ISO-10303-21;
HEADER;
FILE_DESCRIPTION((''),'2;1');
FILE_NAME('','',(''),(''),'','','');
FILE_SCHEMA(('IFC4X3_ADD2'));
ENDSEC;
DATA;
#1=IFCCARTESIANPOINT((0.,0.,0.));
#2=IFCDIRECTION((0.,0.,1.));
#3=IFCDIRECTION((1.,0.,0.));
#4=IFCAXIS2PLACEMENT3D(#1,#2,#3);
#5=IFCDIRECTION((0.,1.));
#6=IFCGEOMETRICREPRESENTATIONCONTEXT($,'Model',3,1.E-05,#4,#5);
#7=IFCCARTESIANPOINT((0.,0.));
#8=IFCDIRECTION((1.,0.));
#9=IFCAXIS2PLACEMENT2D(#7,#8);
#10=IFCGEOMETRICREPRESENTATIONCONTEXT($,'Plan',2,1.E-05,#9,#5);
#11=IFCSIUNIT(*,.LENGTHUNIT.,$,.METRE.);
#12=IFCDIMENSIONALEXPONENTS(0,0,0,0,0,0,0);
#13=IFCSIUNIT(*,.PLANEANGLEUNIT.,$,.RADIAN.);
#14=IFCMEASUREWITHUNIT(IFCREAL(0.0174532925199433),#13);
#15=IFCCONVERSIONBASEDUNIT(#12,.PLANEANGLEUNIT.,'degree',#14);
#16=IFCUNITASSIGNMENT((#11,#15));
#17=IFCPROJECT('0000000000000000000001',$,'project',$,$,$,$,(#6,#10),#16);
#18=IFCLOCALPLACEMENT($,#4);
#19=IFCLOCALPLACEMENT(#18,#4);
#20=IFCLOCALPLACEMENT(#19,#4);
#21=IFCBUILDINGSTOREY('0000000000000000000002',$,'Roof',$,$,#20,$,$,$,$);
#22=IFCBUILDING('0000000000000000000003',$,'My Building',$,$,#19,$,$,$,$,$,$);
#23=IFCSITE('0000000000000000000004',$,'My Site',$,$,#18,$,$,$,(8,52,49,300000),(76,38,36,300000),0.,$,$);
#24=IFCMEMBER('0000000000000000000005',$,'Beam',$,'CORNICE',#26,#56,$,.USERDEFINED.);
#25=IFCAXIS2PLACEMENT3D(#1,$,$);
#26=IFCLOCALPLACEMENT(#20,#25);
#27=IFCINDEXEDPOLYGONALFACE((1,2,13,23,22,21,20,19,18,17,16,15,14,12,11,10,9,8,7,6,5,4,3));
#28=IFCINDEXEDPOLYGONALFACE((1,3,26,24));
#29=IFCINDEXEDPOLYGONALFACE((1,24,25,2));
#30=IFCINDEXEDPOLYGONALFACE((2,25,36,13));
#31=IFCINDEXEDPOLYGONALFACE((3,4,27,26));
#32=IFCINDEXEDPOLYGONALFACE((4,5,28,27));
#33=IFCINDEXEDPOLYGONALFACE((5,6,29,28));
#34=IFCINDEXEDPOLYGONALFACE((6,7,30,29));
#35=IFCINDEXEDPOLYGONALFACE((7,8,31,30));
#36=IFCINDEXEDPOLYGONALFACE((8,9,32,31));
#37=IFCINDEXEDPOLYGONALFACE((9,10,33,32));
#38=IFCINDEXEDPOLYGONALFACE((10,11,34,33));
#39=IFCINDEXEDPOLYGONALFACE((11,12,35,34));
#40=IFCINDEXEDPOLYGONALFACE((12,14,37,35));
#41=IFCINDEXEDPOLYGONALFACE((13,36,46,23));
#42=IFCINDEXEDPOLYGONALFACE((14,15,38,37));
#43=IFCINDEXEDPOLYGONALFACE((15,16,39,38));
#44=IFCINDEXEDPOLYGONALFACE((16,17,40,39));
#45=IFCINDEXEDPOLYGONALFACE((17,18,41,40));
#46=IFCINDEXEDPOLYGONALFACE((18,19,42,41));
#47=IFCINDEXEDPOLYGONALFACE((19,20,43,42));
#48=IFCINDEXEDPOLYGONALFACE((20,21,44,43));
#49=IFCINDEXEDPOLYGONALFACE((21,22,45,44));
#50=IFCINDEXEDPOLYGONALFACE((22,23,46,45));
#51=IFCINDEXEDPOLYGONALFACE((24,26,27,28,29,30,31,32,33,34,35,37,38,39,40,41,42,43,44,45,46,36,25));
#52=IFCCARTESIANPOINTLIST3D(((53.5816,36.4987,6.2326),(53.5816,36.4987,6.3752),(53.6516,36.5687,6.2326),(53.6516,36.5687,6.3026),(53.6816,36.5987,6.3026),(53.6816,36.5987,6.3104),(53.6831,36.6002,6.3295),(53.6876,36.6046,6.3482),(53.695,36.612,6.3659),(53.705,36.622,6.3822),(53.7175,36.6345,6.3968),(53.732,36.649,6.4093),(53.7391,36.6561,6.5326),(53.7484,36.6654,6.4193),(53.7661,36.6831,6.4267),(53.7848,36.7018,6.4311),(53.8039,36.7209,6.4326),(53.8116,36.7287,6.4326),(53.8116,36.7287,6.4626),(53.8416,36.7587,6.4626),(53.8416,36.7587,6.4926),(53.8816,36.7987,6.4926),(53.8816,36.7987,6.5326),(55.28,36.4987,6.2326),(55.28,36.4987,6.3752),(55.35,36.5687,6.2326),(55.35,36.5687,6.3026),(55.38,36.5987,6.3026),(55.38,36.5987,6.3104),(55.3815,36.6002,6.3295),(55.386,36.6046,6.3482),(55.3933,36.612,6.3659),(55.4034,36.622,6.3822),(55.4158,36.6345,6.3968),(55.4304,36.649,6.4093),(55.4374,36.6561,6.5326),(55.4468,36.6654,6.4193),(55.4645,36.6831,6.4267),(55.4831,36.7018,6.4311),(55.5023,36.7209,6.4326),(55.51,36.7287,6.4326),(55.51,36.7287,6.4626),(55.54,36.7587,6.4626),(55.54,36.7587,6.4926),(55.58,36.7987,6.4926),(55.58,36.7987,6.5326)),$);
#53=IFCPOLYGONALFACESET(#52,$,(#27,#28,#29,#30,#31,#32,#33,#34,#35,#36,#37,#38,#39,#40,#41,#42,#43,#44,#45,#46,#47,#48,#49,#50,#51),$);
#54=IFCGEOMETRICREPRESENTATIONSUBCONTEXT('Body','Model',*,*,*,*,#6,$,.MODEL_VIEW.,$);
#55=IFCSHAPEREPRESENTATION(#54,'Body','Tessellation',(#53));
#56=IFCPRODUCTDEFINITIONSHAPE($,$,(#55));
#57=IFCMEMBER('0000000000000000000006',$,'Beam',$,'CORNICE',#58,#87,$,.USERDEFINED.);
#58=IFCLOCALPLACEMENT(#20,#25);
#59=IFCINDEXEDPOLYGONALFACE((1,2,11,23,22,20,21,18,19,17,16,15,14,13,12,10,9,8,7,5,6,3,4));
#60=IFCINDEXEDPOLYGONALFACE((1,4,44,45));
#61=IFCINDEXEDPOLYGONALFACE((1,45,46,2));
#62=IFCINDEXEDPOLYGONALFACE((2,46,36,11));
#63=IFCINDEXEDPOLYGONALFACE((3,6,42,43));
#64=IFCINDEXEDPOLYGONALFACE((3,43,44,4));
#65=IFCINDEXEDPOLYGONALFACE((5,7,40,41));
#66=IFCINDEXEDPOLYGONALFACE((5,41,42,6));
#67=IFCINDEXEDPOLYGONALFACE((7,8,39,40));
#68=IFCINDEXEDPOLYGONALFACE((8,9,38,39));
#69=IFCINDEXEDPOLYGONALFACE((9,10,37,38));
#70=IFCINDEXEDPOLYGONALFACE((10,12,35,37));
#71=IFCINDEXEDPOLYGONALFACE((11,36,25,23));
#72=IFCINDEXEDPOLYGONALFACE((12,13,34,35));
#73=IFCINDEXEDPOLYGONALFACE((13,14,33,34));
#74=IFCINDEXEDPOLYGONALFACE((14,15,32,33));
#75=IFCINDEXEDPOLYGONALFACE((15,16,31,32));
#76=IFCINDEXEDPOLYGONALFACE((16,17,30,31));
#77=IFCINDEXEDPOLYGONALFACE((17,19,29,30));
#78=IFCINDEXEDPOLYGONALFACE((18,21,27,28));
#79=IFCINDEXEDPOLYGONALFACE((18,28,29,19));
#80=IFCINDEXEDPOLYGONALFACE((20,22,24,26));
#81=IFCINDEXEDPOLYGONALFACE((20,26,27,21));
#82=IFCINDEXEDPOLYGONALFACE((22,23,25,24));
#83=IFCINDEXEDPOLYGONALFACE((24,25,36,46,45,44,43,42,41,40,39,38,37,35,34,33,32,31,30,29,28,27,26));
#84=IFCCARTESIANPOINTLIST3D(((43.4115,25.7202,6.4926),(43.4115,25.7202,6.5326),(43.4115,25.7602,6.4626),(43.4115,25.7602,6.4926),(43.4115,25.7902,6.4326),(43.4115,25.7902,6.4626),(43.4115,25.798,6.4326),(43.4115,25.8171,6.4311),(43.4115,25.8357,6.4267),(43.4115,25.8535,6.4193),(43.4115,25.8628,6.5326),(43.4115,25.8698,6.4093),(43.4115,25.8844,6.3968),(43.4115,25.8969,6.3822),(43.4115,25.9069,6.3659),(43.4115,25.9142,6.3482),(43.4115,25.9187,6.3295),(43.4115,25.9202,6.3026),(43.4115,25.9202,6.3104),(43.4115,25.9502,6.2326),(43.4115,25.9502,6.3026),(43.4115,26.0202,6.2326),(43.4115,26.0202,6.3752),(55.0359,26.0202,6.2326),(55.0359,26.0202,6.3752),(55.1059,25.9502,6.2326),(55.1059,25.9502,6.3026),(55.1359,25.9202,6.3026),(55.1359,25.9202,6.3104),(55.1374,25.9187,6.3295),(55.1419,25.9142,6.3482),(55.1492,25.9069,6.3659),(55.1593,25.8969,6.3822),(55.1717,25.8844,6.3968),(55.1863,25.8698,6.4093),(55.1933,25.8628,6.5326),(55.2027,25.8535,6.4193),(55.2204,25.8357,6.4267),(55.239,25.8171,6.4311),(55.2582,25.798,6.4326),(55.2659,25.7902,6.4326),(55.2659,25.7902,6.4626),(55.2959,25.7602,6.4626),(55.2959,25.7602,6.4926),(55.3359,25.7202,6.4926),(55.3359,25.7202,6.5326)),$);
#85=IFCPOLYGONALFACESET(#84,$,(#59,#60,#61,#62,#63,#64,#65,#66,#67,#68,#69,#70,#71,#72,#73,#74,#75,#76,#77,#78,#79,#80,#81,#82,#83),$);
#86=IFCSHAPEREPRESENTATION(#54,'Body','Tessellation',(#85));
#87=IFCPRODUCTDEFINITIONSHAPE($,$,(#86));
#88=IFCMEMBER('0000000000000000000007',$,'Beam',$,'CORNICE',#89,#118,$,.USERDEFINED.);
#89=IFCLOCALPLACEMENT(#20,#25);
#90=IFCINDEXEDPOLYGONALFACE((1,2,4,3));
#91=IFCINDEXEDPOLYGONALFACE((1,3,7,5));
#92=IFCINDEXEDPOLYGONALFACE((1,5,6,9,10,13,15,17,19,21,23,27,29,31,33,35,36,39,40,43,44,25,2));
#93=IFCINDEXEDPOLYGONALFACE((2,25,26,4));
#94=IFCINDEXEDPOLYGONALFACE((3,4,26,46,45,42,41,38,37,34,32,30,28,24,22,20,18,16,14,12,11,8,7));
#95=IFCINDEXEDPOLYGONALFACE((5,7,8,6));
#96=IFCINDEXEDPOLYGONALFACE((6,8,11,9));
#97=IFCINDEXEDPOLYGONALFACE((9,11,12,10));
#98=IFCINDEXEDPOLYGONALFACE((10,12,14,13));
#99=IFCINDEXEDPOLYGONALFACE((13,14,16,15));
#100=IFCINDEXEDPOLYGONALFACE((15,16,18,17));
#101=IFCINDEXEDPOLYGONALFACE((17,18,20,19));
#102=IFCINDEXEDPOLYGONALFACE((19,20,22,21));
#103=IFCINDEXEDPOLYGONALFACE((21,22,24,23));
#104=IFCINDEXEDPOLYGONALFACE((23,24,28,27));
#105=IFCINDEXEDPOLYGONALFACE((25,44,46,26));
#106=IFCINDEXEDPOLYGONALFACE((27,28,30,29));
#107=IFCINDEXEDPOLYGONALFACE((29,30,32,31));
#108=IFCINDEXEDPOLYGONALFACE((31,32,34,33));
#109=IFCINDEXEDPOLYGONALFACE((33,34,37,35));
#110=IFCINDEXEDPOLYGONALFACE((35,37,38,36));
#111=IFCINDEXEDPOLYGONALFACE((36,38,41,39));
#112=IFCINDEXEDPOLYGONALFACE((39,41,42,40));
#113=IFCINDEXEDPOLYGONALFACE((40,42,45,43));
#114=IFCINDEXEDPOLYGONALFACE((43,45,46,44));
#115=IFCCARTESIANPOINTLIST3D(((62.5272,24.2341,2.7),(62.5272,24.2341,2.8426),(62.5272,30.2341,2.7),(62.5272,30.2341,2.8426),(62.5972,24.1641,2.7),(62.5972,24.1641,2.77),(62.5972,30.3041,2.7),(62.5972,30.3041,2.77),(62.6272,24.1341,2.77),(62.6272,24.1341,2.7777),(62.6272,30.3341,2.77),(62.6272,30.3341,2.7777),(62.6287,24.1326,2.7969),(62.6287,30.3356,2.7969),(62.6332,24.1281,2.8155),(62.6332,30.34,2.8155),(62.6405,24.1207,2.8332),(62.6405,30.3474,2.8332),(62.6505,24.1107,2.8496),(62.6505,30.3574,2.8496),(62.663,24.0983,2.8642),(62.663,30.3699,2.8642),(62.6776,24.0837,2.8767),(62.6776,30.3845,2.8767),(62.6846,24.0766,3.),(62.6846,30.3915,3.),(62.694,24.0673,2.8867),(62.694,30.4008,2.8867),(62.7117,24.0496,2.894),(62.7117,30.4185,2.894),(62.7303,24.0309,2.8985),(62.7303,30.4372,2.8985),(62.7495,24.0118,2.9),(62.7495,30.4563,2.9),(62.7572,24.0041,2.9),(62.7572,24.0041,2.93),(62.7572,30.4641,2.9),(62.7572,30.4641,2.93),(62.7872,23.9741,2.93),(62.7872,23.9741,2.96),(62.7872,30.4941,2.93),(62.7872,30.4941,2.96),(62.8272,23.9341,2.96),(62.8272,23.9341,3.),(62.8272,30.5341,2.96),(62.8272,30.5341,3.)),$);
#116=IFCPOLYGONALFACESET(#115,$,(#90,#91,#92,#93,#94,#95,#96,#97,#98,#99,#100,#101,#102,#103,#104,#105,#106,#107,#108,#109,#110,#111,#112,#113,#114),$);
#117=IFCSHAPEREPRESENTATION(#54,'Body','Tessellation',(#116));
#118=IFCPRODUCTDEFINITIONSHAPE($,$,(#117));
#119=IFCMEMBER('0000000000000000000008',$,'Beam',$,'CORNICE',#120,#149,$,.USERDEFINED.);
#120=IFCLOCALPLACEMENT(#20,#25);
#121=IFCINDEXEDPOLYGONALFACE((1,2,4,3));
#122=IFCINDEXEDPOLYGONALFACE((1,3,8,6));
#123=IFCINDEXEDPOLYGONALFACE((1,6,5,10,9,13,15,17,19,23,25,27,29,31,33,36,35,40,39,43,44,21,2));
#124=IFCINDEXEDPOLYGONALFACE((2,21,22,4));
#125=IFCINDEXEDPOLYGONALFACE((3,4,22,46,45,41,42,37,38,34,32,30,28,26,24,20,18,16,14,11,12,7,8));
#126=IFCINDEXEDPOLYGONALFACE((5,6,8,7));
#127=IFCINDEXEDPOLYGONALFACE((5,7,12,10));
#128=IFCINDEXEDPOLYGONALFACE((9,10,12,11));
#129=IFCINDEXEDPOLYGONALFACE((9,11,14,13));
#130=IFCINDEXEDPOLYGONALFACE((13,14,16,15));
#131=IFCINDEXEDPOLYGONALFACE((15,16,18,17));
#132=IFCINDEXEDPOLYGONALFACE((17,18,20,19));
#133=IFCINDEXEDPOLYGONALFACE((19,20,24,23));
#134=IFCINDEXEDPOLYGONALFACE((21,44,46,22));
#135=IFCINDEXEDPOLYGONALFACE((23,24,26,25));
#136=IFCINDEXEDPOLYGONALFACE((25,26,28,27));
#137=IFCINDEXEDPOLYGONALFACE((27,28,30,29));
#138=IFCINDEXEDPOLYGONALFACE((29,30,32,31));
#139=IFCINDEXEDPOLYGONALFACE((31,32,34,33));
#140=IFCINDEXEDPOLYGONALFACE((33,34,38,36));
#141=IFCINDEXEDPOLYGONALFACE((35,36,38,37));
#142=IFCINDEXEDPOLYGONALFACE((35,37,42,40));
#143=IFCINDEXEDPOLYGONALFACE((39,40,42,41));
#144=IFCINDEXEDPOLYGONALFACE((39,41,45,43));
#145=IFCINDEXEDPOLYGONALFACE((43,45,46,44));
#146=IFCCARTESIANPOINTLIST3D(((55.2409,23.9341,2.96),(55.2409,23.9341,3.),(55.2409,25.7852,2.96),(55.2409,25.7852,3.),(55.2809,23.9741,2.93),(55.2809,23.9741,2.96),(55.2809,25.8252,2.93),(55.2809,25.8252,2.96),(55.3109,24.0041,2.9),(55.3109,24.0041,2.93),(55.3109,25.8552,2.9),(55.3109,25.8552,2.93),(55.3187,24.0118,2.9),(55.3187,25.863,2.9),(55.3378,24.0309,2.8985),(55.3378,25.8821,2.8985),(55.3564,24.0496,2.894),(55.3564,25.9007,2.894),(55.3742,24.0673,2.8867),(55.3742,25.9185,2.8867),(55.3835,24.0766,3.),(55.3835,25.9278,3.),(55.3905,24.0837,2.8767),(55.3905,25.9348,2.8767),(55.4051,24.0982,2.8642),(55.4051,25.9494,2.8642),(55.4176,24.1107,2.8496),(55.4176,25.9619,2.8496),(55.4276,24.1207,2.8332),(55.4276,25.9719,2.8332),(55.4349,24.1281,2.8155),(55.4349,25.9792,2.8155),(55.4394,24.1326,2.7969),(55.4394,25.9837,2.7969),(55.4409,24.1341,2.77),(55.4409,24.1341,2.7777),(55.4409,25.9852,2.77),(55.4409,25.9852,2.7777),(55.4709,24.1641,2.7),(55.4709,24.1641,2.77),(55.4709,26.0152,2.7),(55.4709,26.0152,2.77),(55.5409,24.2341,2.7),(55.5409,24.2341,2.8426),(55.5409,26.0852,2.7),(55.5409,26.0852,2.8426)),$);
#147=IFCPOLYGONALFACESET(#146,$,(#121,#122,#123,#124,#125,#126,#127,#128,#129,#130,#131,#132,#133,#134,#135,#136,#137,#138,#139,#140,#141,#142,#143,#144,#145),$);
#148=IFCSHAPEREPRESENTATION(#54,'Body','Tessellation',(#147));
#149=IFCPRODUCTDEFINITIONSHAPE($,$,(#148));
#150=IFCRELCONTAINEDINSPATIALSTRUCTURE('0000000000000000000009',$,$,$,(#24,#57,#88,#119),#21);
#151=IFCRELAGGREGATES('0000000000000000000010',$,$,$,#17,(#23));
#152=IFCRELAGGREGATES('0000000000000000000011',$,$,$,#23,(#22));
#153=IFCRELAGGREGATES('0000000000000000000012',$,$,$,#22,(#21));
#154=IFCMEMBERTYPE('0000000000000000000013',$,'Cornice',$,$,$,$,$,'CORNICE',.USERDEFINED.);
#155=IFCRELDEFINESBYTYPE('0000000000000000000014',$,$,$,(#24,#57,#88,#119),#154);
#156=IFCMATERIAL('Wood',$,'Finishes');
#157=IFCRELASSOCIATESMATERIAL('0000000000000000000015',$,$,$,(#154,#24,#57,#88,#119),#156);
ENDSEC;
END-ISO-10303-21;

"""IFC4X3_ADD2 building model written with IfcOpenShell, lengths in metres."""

from ifc_helpers import new_model, entity, si_unit, converted_unit, direction, frame, origin_with_axes, origin_2d_with_axis, place, context, subcontext, project, spatial, indexed_curve, outline, extrude, clip, halfspace, material, material_profile, profile_set, profile_usage, type_object, element, save


model = new_model("IFC4X3_ADD2")

# Units and contexts
model_context = context("Model", 3, precision=1e-05, world=origin_with_axes(), true_north=direction((0.0, 1.0)))
plan_context = context("Plan", 2, precision=1e-05, world=origin_2d_with_axis(), true_north=direction((0.0, 1.0)))
body_context = subcontext(model_context, "Body", "Model", "MODEL_VIEW")
ifc_project = project(units=[si_unit("LENGTHUNIT", "METRE"), converted_unit("PLANEANGLEUNIT", "degree", entity("IfcReal", 0.0174532925199433), si_unit("PLANEANGLEUNIT", "RADIAN"), dimensions=[0, 0, 0, 0, 0, 0, 0])], contexts=[model_context, plan_context])

# Site, building, storey
site_placement = place(None, origin_with_axes())
site = spatial("IfcSite", under=ifc_project, at=site_placement, Name="My Site", RefLatitude=(8, 52, 49, 300000), RefLongitude=(76, 38, 36, 300000), RefElevation=0.0)
building_placement = place(site_placement, origin_with_axes())
building = spatial("IfcBuilding", under=site, at=building_placement, Name="My Building")
storey_placement = place(building_placement, origin_with_axes())
storey = spatial("IfcBuildingStorey", under=building, at=storey_placement, Name="Roof")

# Members
ifc_material_1 = material(Name="Wood", Category="Finishes")
ifc_material_profile_1 = material_profile(ifc_material_1, outline(indexed_curve([(-0.26, 0.26), (-0.3, 0.26), (-0.3, 0.3), (-0.1574, 0.3), (0.0, 0.1426), (0.0, 0.0), (-0.07, 0.0), (-0.07, 0.07), (-0.1, 0.07), (-0.1, 0.0777), (-0.1015, 0.0969), (-0.106, 0.1155), (-0.1133, 0.1332), (-0.1233, 0.1496), (-0.1358, 0.1642), (-0.1504, 0.1767), (-0.1668, 0.1867), (-0.1845, 0.194), (-0.2031, 0.1985), (-0.2223, 0.2), (-0.23, 0.2), (-0.23, 0.23), (-0.26, 0.23), (-0.26, 0.26)])))
ifc_profile_set_1 = profile_set([ifc_material_profile_1])
member_type = type_object("IfcMemberType", Name="Cornice", ElementType="CORNICE", PredefinedType="USERDEFINED", material=ifc_profile_set_1)
ifc_profile_usage_1 = profile_usage(ifc_profile_set_1, cardinal=5)
member_1_placement = place(storey_placement, frame((55.58, 36.4987, 6.2326), z_axis=(-1.0, 0.0, 0.0), x_axis=(0.0, -1.0, 0.0)))
element("IfcMember", 1, at=member_1_placement, inside=storey, type_object=member_type, material=ifc_profile_usage_1, Name="Beam", ObjectType="CORNICE", PredefinedType="USERDEFINED", context=body_context, shape_type="Clipping", body=[
    clip(clip(extrude(outline(indexed_curve([(-0.26, 0.26), (-0.3, 0.26), (-0.3, 0.3), (-0.1574, 0.3), (0.0, 0.1426), (0.0, 0.0), (-0.07, 0.0), (-0.07, 0.07), (-0.1, 0.07), (-0.1, 0.0777), (-0.1015, 0.0969), (-0.106, 0.1155), (-0.1133, 0.1332), (-0.1233, 0.1496), (-0.1358, 0.1642), (-0.1504, 0.1767), (-0.1668, 0.1867), (-0.1845, 0.194), (-0.2031, 0.1985), (-0.2223, 0.2), (-0.23, 0.2), (-0.23, 0.23), (-0.26, 0.23), (-0.26, 0.26)])), origin_with_axes(), (0.0, 0.0, 1.0), 1.9984), halfspace(frame((-0.3, -6.1726, 0.0), z_axis=(0.707107, 0.0, -0.707107), x_axis=(0.0, -1.0, 0.0)), False)), halfspace(frame((0.0, -6.1726, 1.9984), z_axis=(-0.707107, 0.0, 0.707107), x_axis=(0.0, 1.0, 0.0)), False)),
])
ifc_profile_usage_2 = profile_usage(ifc_profile_set_1, cardinal=5)
member_2_placement = place(storey_placement, frame((43.4115, 26.0202, 6.2326), z_axis=(1.0, 0.0, 0.0), x_axis=(0.0, 1.0, 0.0)))
element("IfcMember", 2, at=member_2_placement, inside=storey, type_object=member_type, material=ifc_profile_usage_2, Name="Beam", ObjectType="CORNICE", PredefinedType="USERDEFINED", context=body_context, shape_type="Clipping", body=[
    clip(extrude(outline(indexed_curve([(-0.26, 0.26), (-0.3, 0.26), (-0.3, 0.3), (-0.1574, 0.3), (0.0, 0.1426), (0.0, 0.0), (-0.07, 0.0), (-0.07, 0.07), (-0.1, 0.07), (-0.1, 0.0777), (-0.1015, 0.0969), (-0.106, 0.1155), (-0.1133, 0.1332), (-0.1233, 0.1496), (-0.1358, 0.1642), (-0.1504, 0.1767), (-0.1668, 0.1867), (-0.1845, 0.194), (-0.2031, 0.1985), (-0.2223, 0.2), (-0.23, 0.2), (-0.23, 0.23), (-0.26, 0.23), (-0.26, 0.26)])), origin_with_axes(), (0.0, 0.0, 1.0), 11.9244), halfspace(frame((-0.3, -6.1726, 11.9244), z_axis=(0.707107, 0.0, 0.707107), x_axis=(0.0, -1.0, 0.0)), False)),
])
ifc_profile_usage_3 = profile_usage(ifc_profile_set_1, cardinal=5)
member_3_placement = place(storey_placement, frame((62.5272, 23.9341, 2.7), z_axis=(0.0, 1.0, 0.0), x_axis=(-1.0, 0.0, 0.0)))
element("IfcMember", 3, at=member_3_placement, inside=storey, type_object=member_type, material=ifc_profile_usage_3, Name="Beam", ObjectType="CORNICE", PredefinedType="USERDEFINED", context=body_context, shape_type="Clipping", body=[
    clip(clip(extrude(outline(indexed_curve([(-0.26, 0.26), (-0.3, 0.26), (-0.3, 0.3), (-0.1574, 0.3), (0.0, 0.1426), (0.0, 0.0), (-0.07, 0.0), (-0.07, 0.07), (-0.1, 0.07), (-0.1, 0.0777), (-0.1015, 0.0969), (-0.106, 0.1155), (-0.1133, 0.1332), (-0.1233, 0.1496), (-0.1358, 0.1642), (-0.1504, 0.1767), (-0.1668, 0.1867), (-0.1845, 0.194), (-0.2031, 0.1985), (-0.2223, 0.2), (-0.23, 0.2), (-0.23, 0.23), (-0.26, 0.23), (-0.26, 0.26)])), origin_with_axes(), (0.0, 0.0, 1.0), 6.6), halfspace(frame((-0.3, -2.7, 6.6), z_axis=(0.707107, 0.0, 0.707107), x_axis=(0.0, -1.0, 0.0)), False)), halfspace(frame((-0.3, -2.7, 0.0), z_axis=(0.707107, 0.0, -0.707107), x_axis=(0.0, -1.0, 0.0)), False)),
])
ifc_profile_usage_4 = profile_usage(ifc_profile_set_1, cardinal=5)
member_4_placement = place(storey_placement, frame((55.5409, 26.0852, 2.7), z_axis=(0.0, -1.0, 0.0), x_axis=(1.0, 0.0, 0.0)))
element("IfcMember", 4, at=member_4_placement, inside=storey, type_object=member_type, material=ifc_profile_usage_4, Name="Beam", ObjectType="CORNICE", PredefinedType="USERDEFINED", context=body_context, shape_type="Clipping", body=[
    clip(clip(extrude(outline(indexed_curve([(-0.26, 0.26), (-0.3, 0.26), (-0.3, 0.3), (-0.1574, 0.3), (0.0, 0.1426), (0.0, 0.0), (-0.07, 0.0), (-0.07, 0.07), (-0.1, 0.07), (-0.1, 0.0777), (-0.1015, 0.0969), (-0.106, 0.1155), (-0.1133, 0.1332), (-0.1233, 0.1496), (-0.1358, 0.1642), (-0.1504, 0.1767), (-0.1668, 0.1867), (-0.1845, 0.194), (-0.2031, 0.1985), (-0.2223, 0.2), (-0.23, 0.2), (-0.23, 0.23), (-0.26, 0.23), (-0.26, 0.26)])), origin_with_axes(), (0.0, 0.0, 1.0), 2.1512), halfspace(frame((-0.3, -2.7, 2.1512), z_axis=(0.707107, 0.0, 0.707107), x_axis=(0.0, -1.0, 0.0)), False)), halfspace(frame((0.0, -2.7, 0.0), z_axis=(-0.707107, 0.0, -0.707107), x_axis=(0.0, 1.0, 0.0)), False)),
])

save(model, "model.ifc")
